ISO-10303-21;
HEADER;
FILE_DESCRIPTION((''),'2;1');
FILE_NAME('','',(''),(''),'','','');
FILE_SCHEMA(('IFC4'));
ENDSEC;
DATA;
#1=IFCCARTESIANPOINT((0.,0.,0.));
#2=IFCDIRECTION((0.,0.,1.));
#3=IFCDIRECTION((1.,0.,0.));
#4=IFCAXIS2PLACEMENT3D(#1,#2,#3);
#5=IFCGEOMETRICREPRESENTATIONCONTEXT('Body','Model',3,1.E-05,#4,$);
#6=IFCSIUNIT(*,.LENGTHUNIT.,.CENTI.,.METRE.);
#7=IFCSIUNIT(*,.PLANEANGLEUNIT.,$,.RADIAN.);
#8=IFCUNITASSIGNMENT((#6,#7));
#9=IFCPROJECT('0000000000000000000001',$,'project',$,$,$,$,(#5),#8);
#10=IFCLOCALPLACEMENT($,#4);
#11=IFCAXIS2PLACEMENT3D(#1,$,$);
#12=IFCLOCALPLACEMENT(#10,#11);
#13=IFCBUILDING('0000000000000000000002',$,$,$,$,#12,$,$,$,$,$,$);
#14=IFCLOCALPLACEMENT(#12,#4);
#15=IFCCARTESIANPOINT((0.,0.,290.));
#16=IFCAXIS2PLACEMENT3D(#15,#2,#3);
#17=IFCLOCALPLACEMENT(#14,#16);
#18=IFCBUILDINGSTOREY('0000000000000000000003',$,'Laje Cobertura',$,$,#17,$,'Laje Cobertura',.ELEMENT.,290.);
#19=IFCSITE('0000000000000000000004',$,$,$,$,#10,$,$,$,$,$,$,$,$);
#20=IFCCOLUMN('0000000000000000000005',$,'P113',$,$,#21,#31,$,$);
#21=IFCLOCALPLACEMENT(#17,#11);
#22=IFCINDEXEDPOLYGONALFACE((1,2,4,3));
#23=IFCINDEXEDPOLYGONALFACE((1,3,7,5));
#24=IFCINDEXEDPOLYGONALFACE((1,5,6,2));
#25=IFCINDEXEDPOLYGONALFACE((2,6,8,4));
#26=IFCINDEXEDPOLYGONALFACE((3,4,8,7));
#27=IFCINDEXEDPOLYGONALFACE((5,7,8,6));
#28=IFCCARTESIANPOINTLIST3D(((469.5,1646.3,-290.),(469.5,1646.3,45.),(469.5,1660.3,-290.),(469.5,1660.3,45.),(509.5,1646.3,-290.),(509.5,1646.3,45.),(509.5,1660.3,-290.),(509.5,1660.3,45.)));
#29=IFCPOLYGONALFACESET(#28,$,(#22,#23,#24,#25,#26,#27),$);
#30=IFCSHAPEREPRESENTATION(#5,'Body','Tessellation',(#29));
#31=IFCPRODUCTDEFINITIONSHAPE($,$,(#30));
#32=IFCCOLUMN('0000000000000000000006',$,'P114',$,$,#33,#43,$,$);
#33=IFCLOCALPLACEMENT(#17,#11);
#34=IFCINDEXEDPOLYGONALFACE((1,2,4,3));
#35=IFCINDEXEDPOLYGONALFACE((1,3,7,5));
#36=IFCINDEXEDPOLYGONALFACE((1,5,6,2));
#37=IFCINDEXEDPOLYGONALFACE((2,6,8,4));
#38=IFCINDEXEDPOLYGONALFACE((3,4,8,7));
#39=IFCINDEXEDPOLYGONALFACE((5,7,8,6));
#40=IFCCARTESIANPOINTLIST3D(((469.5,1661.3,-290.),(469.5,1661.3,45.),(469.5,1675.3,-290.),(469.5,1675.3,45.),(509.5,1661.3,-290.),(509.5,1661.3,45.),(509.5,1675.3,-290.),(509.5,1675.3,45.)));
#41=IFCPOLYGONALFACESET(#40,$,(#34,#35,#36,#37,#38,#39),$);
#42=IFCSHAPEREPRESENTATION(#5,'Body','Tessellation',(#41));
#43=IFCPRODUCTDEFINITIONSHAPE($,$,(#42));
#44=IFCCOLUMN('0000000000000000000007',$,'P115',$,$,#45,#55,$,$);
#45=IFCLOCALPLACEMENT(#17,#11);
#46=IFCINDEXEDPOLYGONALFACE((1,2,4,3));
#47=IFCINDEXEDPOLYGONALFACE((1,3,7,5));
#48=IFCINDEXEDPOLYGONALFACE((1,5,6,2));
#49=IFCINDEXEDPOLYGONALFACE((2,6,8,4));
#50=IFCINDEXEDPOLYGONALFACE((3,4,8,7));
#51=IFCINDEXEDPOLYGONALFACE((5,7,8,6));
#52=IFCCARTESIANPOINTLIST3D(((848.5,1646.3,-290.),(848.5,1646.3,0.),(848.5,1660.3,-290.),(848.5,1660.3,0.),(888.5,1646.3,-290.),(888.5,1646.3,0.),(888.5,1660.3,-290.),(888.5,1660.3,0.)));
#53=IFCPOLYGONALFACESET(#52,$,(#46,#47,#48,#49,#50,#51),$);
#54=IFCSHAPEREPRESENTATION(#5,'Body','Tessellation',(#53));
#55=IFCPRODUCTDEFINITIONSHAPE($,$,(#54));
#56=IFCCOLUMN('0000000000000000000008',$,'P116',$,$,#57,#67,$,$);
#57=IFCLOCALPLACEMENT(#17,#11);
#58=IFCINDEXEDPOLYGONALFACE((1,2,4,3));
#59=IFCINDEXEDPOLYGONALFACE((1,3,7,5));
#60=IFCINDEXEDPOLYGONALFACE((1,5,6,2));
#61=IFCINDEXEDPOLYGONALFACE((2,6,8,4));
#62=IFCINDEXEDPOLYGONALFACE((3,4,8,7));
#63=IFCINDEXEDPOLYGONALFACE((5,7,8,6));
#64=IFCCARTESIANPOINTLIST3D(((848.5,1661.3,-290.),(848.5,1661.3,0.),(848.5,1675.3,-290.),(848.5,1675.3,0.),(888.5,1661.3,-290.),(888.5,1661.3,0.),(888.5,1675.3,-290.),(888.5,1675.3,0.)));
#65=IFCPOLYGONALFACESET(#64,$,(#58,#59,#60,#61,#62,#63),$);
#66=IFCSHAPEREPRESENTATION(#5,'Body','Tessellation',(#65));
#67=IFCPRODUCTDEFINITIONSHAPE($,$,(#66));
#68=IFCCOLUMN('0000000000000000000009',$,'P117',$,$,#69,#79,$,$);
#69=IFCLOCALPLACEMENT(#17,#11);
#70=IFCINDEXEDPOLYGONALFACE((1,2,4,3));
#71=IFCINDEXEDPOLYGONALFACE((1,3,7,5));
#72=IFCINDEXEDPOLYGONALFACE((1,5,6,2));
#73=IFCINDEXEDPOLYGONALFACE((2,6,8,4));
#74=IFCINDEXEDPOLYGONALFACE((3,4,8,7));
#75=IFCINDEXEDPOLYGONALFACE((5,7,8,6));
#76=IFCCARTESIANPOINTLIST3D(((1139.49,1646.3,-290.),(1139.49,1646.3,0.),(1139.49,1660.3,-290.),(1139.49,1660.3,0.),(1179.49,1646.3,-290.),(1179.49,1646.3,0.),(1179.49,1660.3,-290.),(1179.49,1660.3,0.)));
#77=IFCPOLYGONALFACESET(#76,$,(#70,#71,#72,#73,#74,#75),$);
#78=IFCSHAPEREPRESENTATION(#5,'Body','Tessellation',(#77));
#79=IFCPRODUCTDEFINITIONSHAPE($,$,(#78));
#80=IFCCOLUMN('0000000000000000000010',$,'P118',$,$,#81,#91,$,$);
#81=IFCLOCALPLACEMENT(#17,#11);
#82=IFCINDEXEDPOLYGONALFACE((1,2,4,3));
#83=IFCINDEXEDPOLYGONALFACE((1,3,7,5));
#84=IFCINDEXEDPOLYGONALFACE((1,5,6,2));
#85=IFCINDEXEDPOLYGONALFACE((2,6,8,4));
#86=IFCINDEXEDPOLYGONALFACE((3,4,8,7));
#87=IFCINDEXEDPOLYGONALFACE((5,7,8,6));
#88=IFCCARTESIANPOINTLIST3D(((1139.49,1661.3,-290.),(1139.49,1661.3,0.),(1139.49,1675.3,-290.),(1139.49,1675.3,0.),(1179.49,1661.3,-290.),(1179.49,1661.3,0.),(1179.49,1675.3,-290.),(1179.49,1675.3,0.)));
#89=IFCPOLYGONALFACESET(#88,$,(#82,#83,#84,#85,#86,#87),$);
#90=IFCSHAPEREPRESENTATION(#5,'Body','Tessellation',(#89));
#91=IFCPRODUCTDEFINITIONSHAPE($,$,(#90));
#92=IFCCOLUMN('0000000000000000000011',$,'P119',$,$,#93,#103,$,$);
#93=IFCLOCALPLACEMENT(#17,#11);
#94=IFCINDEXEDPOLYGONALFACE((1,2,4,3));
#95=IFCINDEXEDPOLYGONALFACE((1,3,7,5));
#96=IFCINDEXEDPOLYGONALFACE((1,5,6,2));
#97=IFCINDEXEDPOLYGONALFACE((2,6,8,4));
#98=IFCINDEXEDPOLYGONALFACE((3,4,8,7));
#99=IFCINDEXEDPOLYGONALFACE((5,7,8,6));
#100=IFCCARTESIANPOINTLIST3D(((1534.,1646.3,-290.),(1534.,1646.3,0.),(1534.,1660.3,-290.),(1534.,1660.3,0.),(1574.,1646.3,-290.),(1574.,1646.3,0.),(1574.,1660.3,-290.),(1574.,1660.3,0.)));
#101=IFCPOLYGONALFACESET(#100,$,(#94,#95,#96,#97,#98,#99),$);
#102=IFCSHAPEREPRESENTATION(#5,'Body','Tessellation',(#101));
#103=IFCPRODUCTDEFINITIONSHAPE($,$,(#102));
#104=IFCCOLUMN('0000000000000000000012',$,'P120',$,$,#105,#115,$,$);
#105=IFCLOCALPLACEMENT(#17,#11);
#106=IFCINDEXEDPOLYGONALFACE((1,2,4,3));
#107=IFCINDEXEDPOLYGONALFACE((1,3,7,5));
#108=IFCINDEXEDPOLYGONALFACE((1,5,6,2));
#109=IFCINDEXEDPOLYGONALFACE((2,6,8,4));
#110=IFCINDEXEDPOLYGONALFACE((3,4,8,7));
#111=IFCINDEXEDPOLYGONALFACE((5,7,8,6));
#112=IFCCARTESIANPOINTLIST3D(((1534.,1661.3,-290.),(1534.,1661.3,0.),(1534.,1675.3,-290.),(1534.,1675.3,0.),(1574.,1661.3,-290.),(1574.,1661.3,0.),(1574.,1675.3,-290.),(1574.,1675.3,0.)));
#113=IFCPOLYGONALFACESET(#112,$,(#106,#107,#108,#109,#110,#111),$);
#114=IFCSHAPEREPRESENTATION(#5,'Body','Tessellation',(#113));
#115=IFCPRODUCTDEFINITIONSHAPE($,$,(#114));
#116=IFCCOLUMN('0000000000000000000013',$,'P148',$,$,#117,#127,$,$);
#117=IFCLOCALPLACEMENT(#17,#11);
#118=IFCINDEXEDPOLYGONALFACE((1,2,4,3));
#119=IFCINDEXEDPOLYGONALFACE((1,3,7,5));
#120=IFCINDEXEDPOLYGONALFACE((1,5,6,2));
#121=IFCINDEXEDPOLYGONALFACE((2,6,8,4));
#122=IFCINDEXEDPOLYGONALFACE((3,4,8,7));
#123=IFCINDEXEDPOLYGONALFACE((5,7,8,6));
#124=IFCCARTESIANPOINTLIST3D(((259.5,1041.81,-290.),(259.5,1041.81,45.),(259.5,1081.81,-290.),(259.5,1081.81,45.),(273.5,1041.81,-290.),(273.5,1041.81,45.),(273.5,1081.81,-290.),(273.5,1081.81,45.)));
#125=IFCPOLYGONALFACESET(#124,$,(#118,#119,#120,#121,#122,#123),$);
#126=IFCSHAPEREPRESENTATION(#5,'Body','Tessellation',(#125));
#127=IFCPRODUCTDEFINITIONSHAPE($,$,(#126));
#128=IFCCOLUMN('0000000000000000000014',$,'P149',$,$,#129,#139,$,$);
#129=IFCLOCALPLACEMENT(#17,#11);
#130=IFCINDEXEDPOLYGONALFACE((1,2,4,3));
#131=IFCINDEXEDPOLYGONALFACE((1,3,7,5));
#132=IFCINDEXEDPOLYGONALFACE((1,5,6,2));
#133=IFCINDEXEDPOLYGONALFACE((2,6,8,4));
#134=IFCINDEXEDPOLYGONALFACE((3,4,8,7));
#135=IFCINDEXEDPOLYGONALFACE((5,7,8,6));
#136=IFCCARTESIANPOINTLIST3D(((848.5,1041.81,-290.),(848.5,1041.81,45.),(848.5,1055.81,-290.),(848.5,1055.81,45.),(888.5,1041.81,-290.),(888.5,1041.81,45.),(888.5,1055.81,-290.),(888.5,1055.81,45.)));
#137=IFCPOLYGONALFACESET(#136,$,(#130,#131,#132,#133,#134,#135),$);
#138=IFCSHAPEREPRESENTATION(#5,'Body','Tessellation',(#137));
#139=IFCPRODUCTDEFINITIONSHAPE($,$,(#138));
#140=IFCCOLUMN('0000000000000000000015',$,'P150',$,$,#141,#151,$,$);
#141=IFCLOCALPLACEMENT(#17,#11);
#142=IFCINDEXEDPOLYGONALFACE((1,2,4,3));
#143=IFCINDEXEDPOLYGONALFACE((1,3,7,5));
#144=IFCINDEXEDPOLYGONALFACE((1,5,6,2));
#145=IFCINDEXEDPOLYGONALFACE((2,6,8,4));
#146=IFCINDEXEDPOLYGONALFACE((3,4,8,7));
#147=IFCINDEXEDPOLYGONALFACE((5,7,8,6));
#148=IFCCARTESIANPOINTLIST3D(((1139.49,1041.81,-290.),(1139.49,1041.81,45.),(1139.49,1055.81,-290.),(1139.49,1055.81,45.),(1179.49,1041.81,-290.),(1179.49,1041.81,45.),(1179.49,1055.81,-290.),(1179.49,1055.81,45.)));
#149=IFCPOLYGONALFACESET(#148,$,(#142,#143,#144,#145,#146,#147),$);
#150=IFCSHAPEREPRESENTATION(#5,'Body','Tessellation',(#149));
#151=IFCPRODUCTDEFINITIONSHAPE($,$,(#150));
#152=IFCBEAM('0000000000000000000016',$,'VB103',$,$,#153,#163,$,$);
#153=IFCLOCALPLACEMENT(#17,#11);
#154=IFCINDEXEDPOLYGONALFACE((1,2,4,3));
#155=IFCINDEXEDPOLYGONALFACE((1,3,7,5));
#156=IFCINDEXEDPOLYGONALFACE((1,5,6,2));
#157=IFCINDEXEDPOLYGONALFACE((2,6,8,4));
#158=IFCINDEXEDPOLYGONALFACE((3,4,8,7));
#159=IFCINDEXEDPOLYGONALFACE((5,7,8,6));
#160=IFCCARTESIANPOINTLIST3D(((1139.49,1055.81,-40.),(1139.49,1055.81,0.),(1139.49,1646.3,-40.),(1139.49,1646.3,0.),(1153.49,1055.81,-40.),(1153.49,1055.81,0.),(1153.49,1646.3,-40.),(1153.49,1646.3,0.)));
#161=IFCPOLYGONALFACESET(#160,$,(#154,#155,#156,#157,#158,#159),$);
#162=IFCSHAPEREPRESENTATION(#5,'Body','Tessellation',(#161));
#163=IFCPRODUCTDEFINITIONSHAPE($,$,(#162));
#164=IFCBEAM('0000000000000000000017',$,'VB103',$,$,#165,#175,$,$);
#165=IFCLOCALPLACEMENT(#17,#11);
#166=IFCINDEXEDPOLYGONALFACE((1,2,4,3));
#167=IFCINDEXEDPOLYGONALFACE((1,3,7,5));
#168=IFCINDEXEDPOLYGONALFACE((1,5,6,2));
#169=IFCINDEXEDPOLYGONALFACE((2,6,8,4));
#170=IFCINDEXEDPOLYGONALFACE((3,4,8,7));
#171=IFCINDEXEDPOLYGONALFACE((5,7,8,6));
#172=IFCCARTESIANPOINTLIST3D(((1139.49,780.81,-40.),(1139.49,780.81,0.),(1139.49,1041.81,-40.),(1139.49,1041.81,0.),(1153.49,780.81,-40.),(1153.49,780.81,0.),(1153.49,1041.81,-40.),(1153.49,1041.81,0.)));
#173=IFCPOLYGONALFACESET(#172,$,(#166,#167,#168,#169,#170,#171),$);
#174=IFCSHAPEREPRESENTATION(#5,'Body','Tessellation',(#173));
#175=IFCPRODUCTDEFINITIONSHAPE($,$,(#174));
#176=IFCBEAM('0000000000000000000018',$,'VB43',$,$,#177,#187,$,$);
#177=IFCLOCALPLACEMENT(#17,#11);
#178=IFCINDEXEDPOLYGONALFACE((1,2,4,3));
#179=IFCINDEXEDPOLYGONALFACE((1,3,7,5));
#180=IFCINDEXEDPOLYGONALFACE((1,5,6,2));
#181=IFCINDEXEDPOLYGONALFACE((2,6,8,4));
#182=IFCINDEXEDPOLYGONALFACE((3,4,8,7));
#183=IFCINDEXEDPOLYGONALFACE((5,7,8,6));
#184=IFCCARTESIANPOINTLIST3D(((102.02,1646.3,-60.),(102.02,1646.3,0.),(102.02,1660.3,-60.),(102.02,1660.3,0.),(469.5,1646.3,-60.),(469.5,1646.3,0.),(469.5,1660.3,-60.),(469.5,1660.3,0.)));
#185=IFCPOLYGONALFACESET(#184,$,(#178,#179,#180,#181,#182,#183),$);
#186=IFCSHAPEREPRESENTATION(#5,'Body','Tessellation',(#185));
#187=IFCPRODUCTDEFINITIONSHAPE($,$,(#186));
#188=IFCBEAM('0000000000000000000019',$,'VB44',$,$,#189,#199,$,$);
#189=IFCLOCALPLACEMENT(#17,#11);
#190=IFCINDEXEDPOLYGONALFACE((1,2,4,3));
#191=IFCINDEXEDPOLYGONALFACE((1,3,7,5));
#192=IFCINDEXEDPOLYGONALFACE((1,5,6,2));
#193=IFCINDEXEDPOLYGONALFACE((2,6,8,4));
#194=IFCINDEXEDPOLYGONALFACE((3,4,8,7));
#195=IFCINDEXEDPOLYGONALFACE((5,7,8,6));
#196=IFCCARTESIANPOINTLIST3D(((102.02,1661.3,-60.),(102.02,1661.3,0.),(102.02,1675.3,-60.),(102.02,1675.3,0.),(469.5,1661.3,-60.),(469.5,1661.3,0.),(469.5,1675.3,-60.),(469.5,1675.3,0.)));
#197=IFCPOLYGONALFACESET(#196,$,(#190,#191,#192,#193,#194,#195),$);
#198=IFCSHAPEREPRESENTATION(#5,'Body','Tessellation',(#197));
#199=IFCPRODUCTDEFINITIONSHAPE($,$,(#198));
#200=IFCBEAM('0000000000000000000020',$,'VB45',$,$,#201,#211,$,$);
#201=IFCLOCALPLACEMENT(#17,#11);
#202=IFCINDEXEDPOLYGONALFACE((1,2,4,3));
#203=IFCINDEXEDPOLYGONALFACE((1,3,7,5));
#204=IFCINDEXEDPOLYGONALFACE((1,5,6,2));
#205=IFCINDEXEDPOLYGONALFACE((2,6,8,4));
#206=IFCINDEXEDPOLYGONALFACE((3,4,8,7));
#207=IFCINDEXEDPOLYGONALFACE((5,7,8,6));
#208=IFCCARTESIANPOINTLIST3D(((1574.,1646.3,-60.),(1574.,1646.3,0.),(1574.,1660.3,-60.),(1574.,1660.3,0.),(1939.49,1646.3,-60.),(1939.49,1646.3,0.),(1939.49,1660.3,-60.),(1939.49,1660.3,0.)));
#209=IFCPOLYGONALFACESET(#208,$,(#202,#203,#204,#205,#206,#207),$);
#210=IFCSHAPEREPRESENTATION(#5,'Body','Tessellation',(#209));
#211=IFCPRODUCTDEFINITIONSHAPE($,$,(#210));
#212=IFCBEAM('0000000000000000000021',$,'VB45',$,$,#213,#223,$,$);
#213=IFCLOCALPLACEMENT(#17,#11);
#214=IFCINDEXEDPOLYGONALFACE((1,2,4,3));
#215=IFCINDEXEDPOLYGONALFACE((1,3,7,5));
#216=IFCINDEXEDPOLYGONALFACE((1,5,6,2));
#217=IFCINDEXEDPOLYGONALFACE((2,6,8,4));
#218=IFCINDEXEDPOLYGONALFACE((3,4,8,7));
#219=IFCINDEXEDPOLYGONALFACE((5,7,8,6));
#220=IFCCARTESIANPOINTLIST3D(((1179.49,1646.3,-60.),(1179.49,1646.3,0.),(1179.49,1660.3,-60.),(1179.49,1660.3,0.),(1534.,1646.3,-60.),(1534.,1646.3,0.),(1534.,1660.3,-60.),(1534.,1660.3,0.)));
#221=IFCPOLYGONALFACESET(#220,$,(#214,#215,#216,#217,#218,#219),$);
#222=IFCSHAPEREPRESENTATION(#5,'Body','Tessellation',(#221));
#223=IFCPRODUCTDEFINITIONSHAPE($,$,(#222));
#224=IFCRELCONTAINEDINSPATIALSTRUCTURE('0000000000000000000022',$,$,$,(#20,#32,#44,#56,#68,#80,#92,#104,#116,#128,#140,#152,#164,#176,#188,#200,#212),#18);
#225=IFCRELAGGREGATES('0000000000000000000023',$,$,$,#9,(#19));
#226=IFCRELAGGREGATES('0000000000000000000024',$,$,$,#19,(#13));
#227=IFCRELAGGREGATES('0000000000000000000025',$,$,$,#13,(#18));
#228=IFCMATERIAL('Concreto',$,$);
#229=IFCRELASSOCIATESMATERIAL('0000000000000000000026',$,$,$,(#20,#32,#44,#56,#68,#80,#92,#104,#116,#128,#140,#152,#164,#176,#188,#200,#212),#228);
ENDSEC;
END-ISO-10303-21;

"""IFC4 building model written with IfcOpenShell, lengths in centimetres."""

from ifc_helpers import new_model, si_unit, frame, origin, origin_with_axes, origin_2d_with_axis, place, context, project, spatial, rectangle, extrude, material, element, save


model = new_model("IFC4")

# Units and contexts
model_context = context("Model", 3, precision=1e-05, world=origin_with_axes(), identifier="Body")
ifc_project = project(units=[si_unit("LENGTHUNIT", "METRE", prefix="CENTI"), si_unit("PLANEANGLEUNIT", "RADIAN")], contexts=[model_context])

# Site, building, storey
site_placement = place(None, origin_with_axes())
site = spatial("IfcSite", under=ifc_project, at=site_placement)
building_placement = place(site_placement, origin())
building = spatial("IfcBuilding", under=site, at=building_placement)
placement = place(building_placement, origin_with_axes())
storey_placement = place(placement, frame((0.0, 0.0, 290.0), z_axis=(0.0, 0.0, 1.0), x_axis=(1.0, 0.0, 0.0)))
storey = spatial("IfcBuildingStorey", under=building, at=storey_placement, Name="Laje Cobertura", LongName="Laje Cobertura", CompositionType="ELEMENT", Elevation=290.0)

# Columns
ifc_material = material(Name="Concreto")
for number, where, z_axis, x_axis, name in (
    (1, (489.5, 1653.3, 45.0), (0.0, 0.0, 1.0), (1.0, 0.0, 0.0), "P113"),
    (2, (489.5, 1668.3, 45.0), (0.0, 0.0, 1.0), (1.0, 0.0, 0.0), "P114"),
):
    element("IfcColumn", number, at=place(storey_placement, frame(where, z_axis=z_axis, x_axis=x_axis)), inside=storey, material=ifc_material, Name=name, context=model_context, shape_type="SolidModel", body=[
        extrude(rectangle(XDim=14.0, YDim=40.0, at=origin_2d_with_axis()), frame((0.0, 0.0, 0.0), z_axis=(0.0, 0.0, 1.0), x_axis=(0.0, 1.0, 0.0)), (0.0, 0.0, -1.0), 335.0),
    ])
for number, where, z_axis, x_axis, name in (
    (3, (868.5, 1653.3, 0.0), (0.0, 0.0, 1.0), (1.0, 0.0, 0.0), "P115"),
    (4, (868.5, 1668.3, 0.0), (0.0, 0.0, 1.0), (1.0, 0.0, 0.0), "P116"),
    (5, (1159.49, 1653.3, 0.0), (0.0, 0.0, 1.0), (1.0, 0.0, 0.0), "P117"),
    (6, (1159.49, 1668.3, 0.0), (0.0, 0.0, 1.0), (1.0, 0.0, 0.0), "P118"),
    (7, (1554.0, 1653.3, 0.0), (0.0, 0.0, 1.0), (1.0, 0.0, 0.0), "P119"),
    (8, (1554.0, 1668.3, 0.0), (0.0, 0.0, 1.0), (1.0, 0.0, 0.0), "P120"),
):
    element("IfcColumn", number, at=place(storey_placement, frame(where, z_axis=z_axis, x_axis=x_axis)), inside=storey, material=ifc_material, Name=name, context=model_context, shape_type="SolidModel", body=[
        extrude(rectangle(XDim=14.0, YDim=40.0, at=origin_2d_with_axis()), frame((0.0, 0.0, 0.0), z_axis=(0.0, 0.0, 1.0), x_axis=(0.0, -1.0, 0.0)), (0.0, 0.0, -1.0), 290.0),
    ])
column_1_placement = place(storey_placement, frame((266.5, 1061.81, 45.0), z_axis=(0.0, 0.0, 1.0), x_axis=(1.0, 0.0, 0.0)))
element("IfcColumn", 9, at=column_1_placement, inside=storey, material=ifc_material, Name="P148", context=model_context, shape_type="SolidModel", body=[
    extrude(rectangle(XDim=14.0, YDim=40.0, at=origin_2d_with_axis()), origin_with_axes(), (0.0, 0.0, -1.0), 335.0),
])
column_2_placement = place(storey_placement, frame((868.5, 1048.81, 45.0), z_axis=(0.0, 0.0, 1.0), x_axis=(1.0, 0.0, 0.0)))
element("IfcColumn", 10, at=column_2_placement, inside=storey, material=ifc_material, Name="P149", context=model_context, shape_type="SolidModel", body=[
    extrude(rectangle(XDim=14.0, YDim=40.0, at=origin_2d_with_axis()), frame((0.0, 0.0, 0.0), z_axis=(0.0, 0.0, 1.0), x_axis=(0.0, 1.0, 0.0)), (0.0, 0.0, -1.0), 335.0),
])
column_3_placement = place(storey_placement, frame((1159.49, 1048.81, 45.0), z_axis=(0.0, 0.0, 1.0), x_axis=(1.0, 0.0, 0.0)))
element("IfcColumn", 11, at=column_3_placement, inside=storey, material=ifc_material, Name="P150", context=model_context, shape_type="SolidModel", body=[
    extrude(rectangle(XDim=14.0, YDim=40.0, at=origin_2d_with_axis()), frame((0.0, 0.0, 0.0), z_axis=(0.0, 0.0, 1.0), x_axis=(0.0, -1.0, 0.0)), (0.0, 0.0, -1.0), 335.0),
])

# Beams
beam_1_placement = place(storey_placement, frame((1146.49, 1351.06, 0.0), z_axis=(0.0, 0.0, 1.0), x_axis=(1.0, 0.0, 0.0)))
element("IfcBeam", 12, at=beam_1_placement, inside=storey, material=ifc_material, Name="VB103", context=model_context, shape_type="SolidModel", body=[
    extrude(rectangle(XDim=14.0, YDim=40.0, at=origin_2d_with_axis()), frame((0.0, -295.25, -20.0), z_axis=(0.0, 1.0, 0.0), x_axis=(1.0, 0.0, 0.0)), (0.0, 0.0, 1.0), 590.49),
])
beam_2_placement = place(storey_placement, frame((1146.49, 911.31, 0.0), z_axis=(0.0, 0.0, 1.0), x_axis=(1.0, 0.0, 0.0)))
element("IfcBeam", 13, at=beam_2_placement, inside=storey, material=ifc_material, Name="VB103", context=model_context, shape_type="SolidModel", body=[
    extrude(rectangle(XDim=14.0, YDim=40.0, at=origin_2d_with_axis()), frame((0.0, -130.5, -20.0), z_axis=(0.0, 1.0, 0.0), x_axis=(1.0, 0.0, 0.0)), (0.0, 0.0, 1.0), 261.0),
])
for number, where, z_axis, x_axis, name in (
    (14, (285.76, 1653.3, 0.0), (0.0, 0.0, 1.0), (1.0, 0.0, 0.0), "VB43"),
    (15, (285.76, 1668.3, 0.0), (0.0, 0.0, 1.0), (1.0, 0.0, 0.0), "VB44"),
):
    element("IfcBeam", number, at=place(storey_placement, frame(where, z_axis=z_axis, x_axis=x_axis)), inside=storey, material=ifc_material, Name=name, context=model_context, shape_type="SolidModel", body=[
        extrude(rectangle(XDim=14.0, YDim=60.0, at=origin_2d_with_axis()), frame((-183.74, 0.0, -30.0), z_axis=(1.0, 0.0, 0.0), x_axis=(0.0, 1.0, 0.0)), (0.0, 0.0, 1.0), 367.48),
    ])
beam_3_placement = place(storey_placement, frame((1756.74, 1653.3, 0.0), z_axis=(0.0, 0.0, 1.0), x_axis=(1.0, 0.0, 0.0)))
element("IfcBeam", 16, at=beam_3_placement, inside=storey, material=ifc_material, Name="VB45", context=model_context, shape_type="SolidModel", body=[
    extrude(rectangle(XDim=14.0, YDim=60.0, at=origin_2d_with_axis()), frame((-182.75, 0.0, -30.0), z_axis=(1.0, 0.0, 0.0), x_axis=(0.0, 1.0, 0.0)), (0.0, 0.0, 1.0), 365.49),
])
beam_4_placement = place(storey_placement, frame((1356.74, 1653.3, 0.0), z_axis=(0.0, 0.0, 1.0), x_axis=(1.0, 0.0, 0.0)))
element("IfcBeam", 17, at=beam_4_placement, inside=storey, material=ifc_material, Name="VB45", context=model_context, shape_type="SolidModel", body=[
    extrude(rectangle(XDim=14.0, YDim=60.0, at=origin_2d_with_axis()), frame((-177.25, 0.0, -30.0), z_axis=(1.0, 0.0, 0.0), x_axis=(0.0, 1.0, 0.0)), (0.0, 0.0, 1.0), 354.51),
])

save(model, "model.ifc")
